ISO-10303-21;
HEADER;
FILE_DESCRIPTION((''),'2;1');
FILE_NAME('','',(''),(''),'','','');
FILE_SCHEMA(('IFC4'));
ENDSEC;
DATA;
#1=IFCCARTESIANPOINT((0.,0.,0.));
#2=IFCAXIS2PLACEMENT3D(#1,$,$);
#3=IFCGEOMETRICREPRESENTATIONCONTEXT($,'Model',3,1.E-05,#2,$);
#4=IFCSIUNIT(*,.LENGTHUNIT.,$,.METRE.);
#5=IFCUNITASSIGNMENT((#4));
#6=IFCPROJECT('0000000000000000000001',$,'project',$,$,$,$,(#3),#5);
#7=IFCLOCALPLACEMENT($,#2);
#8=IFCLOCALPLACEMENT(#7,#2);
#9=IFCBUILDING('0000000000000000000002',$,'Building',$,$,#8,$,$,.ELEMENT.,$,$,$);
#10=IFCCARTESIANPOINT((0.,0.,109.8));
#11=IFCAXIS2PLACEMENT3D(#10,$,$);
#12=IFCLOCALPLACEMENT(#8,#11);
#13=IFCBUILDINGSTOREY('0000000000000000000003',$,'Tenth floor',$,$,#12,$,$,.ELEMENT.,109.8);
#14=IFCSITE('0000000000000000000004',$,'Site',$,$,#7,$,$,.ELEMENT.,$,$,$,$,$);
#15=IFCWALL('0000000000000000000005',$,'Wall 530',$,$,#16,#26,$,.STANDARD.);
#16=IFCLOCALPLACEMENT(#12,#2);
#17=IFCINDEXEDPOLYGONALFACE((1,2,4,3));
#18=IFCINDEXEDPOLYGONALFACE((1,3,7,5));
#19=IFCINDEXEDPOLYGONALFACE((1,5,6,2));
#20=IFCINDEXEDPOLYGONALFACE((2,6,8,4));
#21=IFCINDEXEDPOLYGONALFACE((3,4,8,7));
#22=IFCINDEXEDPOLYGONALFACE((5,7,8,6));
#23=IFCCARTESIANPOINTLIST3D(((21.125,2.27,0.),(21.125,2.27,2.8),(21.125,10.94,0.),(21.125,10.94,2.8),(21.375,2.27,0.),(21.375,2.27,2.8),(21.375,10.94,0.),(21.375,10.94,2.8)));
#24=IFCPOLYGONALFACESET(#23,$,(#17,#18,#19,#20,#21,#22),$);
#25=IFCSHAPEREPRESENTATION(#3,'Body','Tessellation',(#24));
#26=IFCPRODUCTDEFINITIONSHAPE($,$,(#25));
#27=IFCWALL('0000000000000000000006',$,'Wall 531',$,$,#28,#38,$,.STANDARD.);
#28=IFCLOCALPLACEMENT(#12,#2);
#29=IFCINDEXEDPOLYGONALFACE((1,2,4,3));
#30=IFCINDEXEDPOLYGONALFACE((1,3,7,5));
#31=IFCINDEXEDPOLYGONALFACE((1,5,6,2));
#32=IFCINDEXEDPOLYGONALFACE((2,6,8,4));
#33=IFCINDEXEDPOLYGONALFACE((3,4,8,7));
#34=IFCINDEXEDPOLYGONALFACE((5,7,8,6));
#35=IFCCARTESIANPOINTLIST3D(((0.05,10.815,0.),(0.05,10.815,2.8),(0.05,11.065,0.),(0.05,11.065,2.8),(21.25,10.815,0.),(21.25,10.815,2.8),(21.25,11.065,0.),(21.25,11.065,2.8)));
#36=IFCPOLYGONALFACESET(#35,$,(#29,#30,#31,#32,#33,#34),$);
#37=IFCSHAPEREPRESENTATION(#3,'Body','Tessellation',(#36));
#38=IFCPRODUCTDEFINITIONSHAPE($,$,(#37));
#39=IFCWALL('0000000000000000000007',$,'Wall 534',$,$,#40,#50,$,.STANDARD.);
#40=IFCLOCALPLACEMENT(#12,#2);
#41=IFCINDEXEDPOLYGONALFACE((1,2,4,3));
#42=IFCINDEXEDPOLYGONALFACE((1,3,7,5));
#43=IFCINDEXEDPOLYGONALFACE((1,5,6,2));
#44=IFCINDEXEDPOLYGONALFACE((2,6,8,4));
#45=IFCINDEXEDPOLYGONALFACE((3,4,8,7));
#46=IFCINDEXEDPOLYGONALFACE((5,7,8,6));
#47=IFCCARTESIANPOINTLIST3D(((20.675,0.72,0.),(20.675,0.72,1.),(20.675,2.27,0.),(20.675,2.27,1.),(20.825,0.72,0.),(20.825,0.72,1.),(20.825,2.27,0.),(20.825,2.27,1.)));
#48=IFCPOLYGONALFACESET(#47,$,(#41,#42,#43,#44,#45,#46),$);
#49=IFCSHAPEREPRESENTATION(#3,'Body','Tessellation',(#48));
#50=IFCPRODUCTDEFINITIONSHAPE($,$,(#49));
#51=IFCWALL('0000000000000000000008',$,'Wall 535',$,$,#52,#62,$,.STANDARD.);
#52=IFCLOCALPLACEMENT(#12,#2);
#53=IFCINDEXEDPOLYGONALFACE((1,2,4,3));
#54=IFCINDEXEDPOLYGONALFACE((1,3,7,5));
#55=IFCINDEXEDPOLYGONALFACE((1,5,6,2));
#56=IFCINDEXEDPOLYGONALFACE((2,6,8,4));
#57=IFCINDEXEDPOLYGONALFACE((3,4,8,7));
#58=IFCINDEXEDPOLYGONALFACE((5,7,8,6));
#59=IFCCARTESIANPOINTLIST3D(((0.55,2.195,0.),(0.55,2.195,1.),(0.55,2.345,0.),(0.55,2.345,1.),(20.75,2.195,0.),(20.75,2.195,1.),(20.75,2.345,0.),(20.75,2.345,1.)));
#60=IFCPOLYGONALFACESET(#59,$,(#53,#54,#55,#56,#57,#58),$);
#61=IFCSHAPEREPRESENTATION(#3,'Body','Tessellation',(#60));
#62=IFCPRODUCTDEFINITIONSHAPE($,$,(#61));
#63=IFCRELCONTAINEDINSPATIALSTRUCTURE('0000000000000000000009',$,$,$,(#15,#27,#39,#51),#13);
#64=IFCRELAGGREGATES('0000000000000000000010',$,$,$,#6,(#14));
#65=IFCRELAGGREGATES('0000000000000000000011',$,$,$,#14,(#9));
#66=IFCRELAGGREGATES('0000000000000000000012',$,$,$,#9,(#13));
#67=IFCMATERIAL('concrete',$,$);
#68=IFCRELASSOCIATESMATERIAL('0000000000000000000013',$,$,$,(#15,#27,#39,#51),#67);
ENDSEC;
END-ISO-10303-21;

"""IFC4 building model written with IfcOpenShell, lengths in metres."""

from ifc_helpers import new_model, si_unit, frame, frame_2d, origin, place, context, project, spatial, rectangle, extrude, material, element, save


model = new_model("IFC4")

# Units and contexts
model_context = context("Model", 3, precision=1e-05, world=origin())
ifc_project = project(units=[si_unit("LENGTHUNIT", "METRE")], contexts=[model_context])

# Site, building, storey
site_placement = place(None, origin())
site = spatial("IfcSite", under=ifc_project, at=site_placement, Name="Site", CompositionType="ELEMENT")
building_placement = place(site_placement, origin())
building = spatial("IfcBuilding", under=site, at=building_placement, Name="Building", CompositionType="ELEMENT")
storey_placement = place(building_placement, frame((0.0, 0.0, 109.8)))
storey = spatial("IfcBuildingStorey", under=building, at=storey_placement, Name="Tenth floor", CompositionType="ELEMENT", Elevation=109.8)

# Walls
ifc_material = material(Name="concrete")
wall_1_placement = place(storey_placement, frame((21.25, 2.27, 0.0), z_axis=(0.0, 0.0, 1.0), x_axis=(0.0, 1.0, 0.0)))
element("IfcWall", 1, at=wall_1_placement, inside=storey, material=ifc_material, Name="Wall 530", PredefinedType="STANDARD", context=model_context, shape_type="SweptSolid", body=[
    extrude(rectangle(XDim=8.67, YDim=0.25, at=frame_2d((4.335, 0.0))), origin(), (0.0, 0.0, 1.0), 2.8),
])
wall_2_placement = place(storey_placement, frame((21.25, 10.94, 0.0), z_axis=(0.0, 0.0, 1.0), x_axis=(-1.0, 0.0, 0.0)))
element("IfcWall", 2, at=wall_2_placement, inside=storey, material=ifc_material, Name="Wall 531", PredefinedType="STANDARD", context=model_context, shape_type="SweptSolid", body=[
    extrude(rectangle(XDim=21.2, YDim=0.25, at=frame_2d((10.6, 0.0))), origin(), (0.0, 0.0, 1.0), 2.8),
])
wall_3_placement = place(storey_placement, frame((20.75, 0.72, 0.0), z_axis=(0.0, 0.0, 1.0), x_axis=(0.0, 1.0, 0.0)))
element("IfcWall", 3, at=wall_3_placement, inside=storey, material=ifc_material, Name="Wall 534", PredefinedType="STANDARD", context=model_context, shape_type="SweptSolid", body=[
    extrude(rectangle(XDim=1.55, YDim=0.15, at=frame_2d((0.775, 0.0))), origin(), (0.0, 0.0, 1.0), 1.0),
])
wall_4_placement = place(storey_placement, frame((20.75, 2.27, 0.0), z_axis=(0.0, 0.0, 1.0), x_axis=(-1.0, 0.0, 0.0)))
element("IfcWall", 4, at=wall_4_placement, inside=storey, material=ifc_material, Name="Wall 535", PredefinedType="STANDARD", context=model_context, shape_type="SweptSolid", body=[
    extrude(rectangle(XDim=20.2, YDim=0.15, at=frame_2d((10.1, 0.0))), origin(), (0.0, 0.0, 1.0), 1.0),
])

save(model, "model.ifc")
